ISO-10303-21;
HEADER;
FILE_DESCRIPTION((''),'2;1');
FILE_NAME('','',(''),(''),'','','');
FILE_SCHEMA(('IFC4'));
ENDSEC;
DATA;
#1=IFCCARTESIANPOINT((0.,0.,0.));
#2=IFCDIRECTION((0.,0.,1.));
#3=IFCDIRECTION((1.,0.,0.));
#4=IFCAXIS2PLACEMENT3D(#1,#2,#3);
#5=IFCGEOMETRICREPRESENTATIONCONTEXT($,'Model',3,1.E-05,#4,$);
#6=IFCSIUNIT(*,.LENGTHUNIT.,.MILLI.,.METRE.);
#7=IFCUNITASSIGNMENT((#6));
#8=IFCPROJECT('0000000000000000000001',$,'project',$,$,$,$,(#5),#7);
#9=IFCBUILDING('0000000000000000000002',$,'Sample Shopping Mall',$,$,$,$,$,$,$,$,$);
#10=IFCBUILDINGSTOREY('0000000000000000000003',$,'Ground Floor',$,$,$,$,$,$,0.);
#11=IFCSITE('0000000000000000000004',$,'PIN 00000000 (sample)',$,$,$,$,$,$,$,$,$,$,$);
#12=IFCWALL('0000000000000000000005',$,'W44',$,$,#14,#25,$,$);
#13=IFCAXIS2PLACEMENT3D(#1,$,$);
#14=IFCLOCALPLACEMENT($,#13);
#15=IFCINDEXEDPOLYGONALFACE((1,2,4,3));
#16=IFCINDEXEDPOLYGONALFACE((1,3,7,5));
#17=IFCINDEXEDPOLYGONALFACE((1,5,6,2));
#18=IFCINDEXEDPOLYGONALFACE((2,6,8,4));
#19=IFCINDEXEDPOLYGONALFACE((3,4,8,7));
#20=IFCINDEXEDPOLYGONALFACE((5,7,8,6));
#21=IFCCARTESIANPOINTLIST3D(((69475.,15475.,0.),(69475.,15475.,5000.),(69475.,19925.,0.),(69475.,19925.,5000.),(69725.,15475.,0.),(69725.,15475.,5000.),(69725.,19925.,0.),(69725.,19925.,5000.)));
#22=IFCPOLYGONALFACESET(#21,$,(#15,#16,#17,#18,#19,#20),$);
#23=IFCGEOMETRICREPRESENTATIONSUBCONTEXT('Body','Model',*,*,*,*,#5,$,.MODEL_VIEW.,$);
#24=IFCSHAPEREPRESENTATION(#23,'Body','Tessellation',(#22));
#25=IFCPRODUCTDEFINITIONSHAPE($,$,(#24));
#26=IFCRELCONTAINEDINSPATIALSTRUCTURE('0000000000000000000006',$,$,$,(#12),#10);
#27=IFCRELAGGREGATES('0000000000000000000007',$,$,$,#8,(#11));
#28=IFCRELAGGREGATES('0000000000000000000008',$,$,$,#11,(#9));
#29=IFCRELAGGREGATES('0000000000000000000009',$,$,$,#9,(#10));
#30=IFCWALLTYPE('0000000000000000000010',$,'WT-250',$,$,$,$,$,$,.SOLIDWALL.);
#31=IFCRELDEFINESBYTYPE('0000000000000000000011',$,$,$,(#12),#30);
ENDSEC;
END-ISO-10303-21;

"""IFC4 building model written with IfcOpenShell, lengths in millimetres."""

from ifc_helpers import new_model, si_unit, frame, origin_with_axes, place, context, subcontext, project, spatial, indexed_curve, outline, extrude, type_object, element, save


model = new_model("IFC4")

# Units and contexts
model_context = context("Model", 3, precision=1e-05, world=origin_with_axes())
body_context = subcontext(model_context, "Body", "Model", "MODEL_VIEW")
ifc_project = project(units=[si_unit("LENGTHUNIT", "METRE", prefix="MILLI")], contexts=[model_context])

# Site, building, storey
site = spatial("IfcSite", under=ifc_project, Name="PIN 00000000 (sample)")
building = spatial("IfcBuilding", under=site, Name="Sample Shopping Mall")
storey = spatial("IfcBuildingStorey", under=building, Name="Ground Floor", Elevation=0.0)

# Shared definitions
wall_type_1 = type_object("IfcWallType", Name="WT-250", PredefinedType="SOLIDWALL")

# Wall
for number, where, z_axis, x_axis, name in (
    (1, (69725.0, 15475.0, 0.0), (0.0, 0.0, 1.0), (0.0, 1.0, 0.0), "W44"),
):
    element("IfcWall", number, at=place(None, frame(where, z_axis=z_axis, x_axis=x_axis)), inside=storey, type_object=wall_type_1, Name=name, context=body_context, shape_type="SweptSolid", body=[
        extrude(outline(indexed_curve([(0.0, 0.0), (0.0, 250.0), (4450.0, 250.0), (4450.0, 0.0), (0.0, 0.0)], self_intersect=False)), origin_with_axes(), (0.0, 0.0, 1.0), 5000.0),
    ])

save(model, "model.ifc")
